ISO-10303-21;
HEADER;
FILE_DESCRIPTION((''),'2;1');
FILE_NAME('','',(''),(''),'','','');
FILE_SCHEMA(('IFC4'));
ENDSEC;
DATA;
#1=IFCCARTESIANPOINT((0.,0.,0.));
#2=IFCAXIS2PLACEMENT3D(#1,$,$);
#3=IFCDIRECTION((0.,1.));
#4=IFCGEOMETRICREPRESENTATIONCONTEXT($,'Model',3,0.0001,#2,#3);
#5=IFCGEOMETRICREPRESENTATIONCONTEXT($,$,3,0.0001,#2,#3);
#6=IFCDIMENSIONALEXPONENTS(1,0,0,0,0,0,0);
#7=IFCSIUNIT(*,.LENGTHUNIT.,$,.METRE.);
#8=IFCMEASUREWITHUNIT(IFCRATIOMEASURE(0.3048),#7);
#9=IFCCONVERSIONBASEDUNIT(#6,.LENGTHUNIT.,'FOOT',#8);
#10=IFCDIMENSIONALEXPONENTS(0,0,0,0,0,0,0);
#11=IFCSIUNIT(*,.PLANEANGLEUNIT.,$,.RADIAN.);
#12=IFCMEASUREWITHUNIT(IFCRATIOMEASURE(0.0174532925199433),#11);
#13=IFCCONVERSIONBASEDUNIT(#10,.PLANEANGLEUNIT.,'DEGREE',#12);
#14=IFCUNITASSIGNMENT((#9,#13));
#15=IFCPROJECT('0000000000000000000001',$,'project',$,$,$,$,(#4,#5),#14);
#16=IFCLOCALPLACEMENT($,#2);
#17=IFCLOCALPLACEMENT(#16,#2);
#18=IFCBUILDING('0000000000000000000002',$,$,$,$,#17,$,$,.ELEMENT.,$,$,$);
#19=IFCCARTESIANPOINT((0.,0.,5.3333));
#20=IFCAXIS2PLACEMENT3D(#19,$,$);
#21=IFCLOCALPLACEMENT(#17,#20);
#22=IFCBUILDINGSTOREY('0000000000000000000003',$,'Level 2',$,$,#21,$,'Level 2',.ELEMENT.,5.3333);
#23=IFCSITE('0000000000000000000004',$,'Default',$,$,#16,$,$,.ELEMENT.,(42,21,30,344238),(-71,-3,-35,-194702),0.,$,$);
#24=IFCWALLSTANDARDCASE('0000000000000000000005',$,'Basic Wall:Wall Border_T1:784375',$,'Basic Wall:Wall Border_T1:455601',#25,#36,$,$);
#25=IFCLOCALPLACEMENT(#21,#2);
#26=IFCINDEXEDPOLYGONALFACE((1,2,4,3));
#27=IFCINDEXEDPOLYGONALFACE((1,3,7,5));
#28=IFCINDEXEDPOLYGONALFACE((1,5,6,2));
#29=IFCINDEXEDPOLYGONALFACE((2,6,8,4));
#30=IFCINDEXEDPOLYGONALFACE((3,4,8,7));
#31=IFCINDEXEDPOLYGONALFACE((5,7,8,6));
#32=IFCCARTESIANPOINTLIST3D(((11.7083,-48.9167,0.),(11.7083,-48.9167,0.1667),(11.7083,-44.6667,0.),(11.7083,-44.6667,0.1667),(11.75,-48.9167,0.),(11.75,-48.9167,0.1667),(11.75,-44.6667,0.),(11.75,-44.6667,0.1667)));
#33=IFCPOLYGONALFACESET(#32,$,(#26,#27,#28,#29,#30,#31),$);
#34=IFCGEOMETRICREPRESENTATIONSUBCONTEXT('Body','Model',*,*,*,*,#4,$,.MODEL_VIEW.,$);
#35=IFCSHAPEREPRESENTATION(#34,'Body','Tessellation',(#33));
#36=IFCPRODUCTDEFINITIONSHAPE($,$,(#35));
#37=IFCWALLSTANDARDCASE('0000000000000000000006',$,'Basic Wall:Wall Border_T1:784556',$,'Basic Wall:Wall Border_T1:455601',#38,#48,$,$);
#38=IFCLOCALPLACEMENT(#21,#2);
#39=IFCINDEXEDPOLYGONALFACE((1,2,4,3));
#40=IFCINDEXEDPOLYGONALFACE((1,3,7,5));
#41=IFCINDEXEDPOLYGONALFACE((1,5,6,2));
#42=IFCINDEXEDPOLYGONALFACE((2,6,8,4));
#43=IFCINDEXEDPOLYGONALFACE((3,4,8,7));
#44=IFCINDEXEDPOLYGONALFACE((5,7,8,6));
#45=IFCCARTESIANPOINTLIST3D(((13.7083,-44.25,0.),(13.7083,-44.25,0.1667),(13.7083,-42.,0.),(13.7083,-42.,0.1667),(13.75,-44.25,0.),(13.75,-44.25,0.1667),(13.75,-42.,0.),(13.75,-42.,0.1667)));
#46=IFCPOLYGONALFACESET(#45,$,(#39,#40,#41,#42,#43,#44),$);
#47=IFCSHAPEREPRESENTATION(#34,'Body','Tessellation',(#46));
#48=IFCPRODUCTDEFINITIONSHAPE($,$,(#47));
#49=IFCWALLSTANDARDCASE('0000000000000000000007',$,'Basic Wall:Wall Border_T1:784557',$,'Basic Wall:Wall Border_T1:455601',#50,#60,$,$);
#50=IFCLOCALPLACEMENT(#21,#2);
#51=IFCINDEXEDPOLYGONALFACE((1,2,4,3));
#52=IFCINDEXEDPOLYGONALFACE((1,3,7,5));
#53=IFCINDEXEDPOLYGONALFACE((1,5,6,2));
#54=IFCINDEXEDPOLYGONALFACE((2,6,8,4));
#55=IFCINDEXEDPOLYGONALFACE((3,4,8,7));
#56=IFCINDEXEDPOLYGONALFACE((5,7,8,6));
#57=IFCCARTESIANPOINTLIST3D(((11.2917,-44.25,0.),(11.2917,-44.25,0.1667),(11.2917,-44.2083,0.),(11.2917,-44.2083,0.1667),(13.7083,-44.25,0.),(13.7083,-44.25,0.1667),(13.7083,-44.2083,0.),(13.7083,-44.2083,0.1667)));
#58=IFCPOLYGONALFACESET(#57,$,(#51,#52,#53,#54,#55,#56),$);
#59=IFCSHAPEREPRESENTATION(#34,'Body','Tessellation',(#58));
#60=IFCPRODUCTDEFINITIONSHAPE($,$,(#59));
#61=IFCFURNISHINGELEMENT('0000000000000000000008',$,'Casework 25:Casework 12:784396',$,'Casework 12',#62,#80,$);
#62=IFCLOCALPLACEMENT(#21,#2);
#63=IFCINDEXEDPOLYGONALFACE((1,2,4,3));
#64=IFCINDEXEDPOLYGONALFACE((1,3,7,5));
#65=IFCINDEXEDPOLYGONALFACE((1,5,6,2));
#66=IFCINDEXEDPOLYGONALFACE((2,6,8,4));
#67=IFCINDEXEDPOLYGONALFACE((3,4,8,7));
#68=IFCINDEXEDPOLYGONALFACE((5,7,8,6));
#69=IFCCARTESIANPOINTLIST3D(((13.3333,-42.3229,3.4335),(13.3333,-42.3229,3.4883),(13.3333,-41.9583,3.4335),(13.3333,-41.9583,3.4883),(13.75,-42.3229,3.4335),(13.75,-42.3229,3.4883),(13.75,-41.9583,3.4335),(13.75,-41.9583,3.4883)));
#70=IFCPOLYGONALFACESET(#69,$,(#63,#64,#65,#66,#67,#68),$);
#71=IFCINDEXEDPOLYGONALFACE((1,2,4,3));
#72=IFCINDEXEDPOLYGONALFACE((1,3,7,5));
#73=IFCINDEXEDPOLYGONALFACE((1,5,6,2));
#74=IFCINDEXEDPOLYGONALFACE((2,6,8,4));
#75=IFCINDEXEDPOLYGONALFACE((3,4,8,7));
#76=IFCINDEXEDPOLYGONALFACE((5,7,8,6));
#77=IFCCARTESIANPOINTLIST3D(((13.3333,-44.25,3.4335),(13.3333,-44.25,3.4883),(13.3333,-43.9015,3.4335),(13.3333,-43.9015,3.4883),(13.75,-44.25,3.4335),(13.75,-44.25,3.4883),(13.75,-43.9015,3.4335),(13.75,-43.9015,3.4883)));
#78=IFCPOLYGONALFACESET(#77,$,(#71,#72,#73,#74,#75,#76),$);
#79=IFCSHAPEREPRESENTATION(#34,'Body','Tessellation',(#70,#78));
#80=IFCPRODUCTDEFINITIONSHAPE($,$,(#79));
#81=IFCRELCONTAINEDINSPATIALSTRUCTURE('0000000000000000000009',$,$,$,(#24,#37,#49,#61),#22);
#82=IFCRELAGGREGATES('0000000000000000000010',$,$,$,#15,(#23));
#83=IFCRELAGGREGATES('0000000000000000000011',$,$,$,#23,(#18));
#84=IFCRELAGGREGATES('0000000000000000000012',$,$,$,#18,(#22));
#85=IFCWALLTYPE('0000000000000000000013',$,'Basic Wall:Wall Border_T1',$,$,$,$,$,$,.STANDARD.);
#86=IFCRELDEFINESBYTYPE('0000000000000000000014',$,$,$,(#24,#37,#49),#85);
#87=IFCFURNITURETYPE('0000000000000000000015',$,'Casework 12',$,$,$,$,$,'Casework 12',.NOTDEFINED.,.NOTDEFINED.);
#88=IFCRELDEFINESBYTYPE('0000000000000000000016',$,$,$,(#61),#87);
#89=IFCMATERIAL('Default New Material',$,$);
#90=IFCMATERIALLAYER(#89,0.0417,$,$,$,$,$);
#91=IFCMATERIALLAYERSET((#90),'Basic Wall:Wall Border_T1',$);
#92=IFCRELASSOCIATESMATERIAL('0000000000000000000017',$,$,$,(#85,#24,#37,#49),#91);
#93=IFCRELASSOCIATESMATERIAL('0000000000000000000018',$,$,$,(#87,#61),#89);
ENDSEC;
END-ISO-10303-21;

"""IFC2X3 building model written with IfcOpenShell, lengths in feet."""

from ifc_helpers import new_model, entity, si_unit, converted_unit, direction, frame, frame_2d, origin, origin_2d_with_axis, place, context, subcontext, project, spatial, rectangle, extrude, source, transform, mapped, material, layer, layer_set, layer_usage, type_object, type_shapes, element, save


model = new_model("IFC2X3")

# Units and contexts
model_context = context("Model", 3, precision=0.0001, world=origin(), true_north=direction((0.0, 1.0)))
context_of_model = context(None, 3, precision=0.0001, world=origin(), true_north=direction((0.0, 1.0)))
body_context = subcontext(model_context, "Body", "Model", "MODEL_VIEW")
ifc_project = project(units=[converted_unit("LENGTHUNIT", "FOOT", entity("IfcRatioMeasure", 0.3048), si_unit("LENGTHUNIT", "METRE"), dimensions=[1, 0, 0, 0, 0, 0, 0]), converted_unit("PLANEANGLEUNIT", "DEGREE", entity("IfcRatioMeasure", 0.0174532925199433), si_unit("PLANEANGLEUNIT", "RADIAN"), dimensions=[0, 0, 0, 0, 0, 0, 0])], contexts=[model_context, context_of_model])

# Site, building, storey
site_placement = place(None, origin())
site = spatial("IfcSite", under=ifc_project, at=site_placement, Name="Default", CompositionType="ELEMENT", RefLatitude=(42, 21, 30, 344238), RefLongitude=(-71, -3, -35, -194702), RefElevation=0.0)
building_placement = place(site_placement, origin())
building = spatial("IfcBuilding", under=site, at=building_placement, CompositionType="ELEMENT")
storey_placement = place(building_placement, frame((0.0, 0.0, 5.3333)))
storey = spatial("IfcBuildingStorey", under=building, at=storey_placement, Name="Level 2", LongName="Level 2", CompositionType="ELEMENT", Elevation=5.3333)

# Shared definitions
ifc_material_1 = material(Name="Default New Material")

# Walls
ifc_layer_1 = layer(ifc_material_1, 0.0417)
ifc_layer_set_1 = layer_set([ifc_layer_1], Name="Basic Wall:Wall Border_T1")
wall_type_1 = type_object("IfcWallType", Name="Basic Wall:Wall Border_T1", PredefinedType="STANDARD", material=ifc_layer_set_1)
ifc_layer_usage_1 = layer_usage(ifc_layer_set_1, "AXIS2", "NEGATIVE", 0.0208)
wall_1_placement = place(storey_placement, frame((11.7292, -44.6667, 0.0), z_axis=(0.0, 0.0, 1.0), x_axis=(0.0, -1.0, 0.0)))
element("IfcWallStandardCase", 1, at=wall_1_placement, inside=storey, type_object=wall_type_1, material=ifc_layer_usage_1, Name="Basic Wall:Wall Border_T1:784375", ObjectType="Basic Wall:Wall Border_T1:455601", context=body_context, shape_type="SweptSolid", body=[
    extrude(rectangle(XDim=4.25, YDim=0.0417, at=frame_2d((2.125, 0.0), x_axis=(-1.0, 0.0))), origin(), (0.0, 0.0, 1.0), 0.1667),
])
ifc_layer_usage_2 = layer_usage(ifc_layer_set_1, "AXIS2", "POSITIVE", -0.0208)
wall_2_placement = place(storey_placement, frame((13.7292, -42.0, 0.0), z_axis=(0.0, 0.0, 1.0), x_axis=(0.0, -1.0, 0.0)))
element("IfcWallStandardCase", 2, at=wall_2_placement, inside=storey, type_object=wall_type_1, material=ifc_layer_usage_2, Name="Basic Wall:Wall Border_T1:784556", ObjectType="Basic Wall:Wall Border_T1:455601", context=body_context, shape_type="SweptSolid", body=[
    extrude(rectangle(XDim=2.25, YDim=0.0417, at=frame_2d((1.125, 0.0), x_axis=(-1.0, 0.0))), origin(), (0.0, 0.0, 1.0), 0.1667),
])
ifc_layer_usage_3 = layer_usage(ifc_layer_set_1, "AXIS2", "POSITIVE", -0.0208)
wall_3_placement = place(storey_placement, frame((13.7083, -44.2292, 0.0), z_axis=(0.0, 0.0, 1.0), x_axis=(-1.0, 0.0, 0.0)))
element("IfcWallStandardCase", 3, at=wall_3_placement, inside=storey, type_object=wall_type_1, material=ifc_layer_usage_3, Name="Basic Wall:Wall Border_T1:784557", ObjectType="Basic Wall:Wall Border_T1:455601", context=body_context, shape_type="SweptSolid", body=[
    extrude(rectangle(XDim=2.4167, YDim=0.0417, at=frame_2d((1.2083, 0.0), x_axis=(-1.0, 0.0))), origin(), (0.0, 0.0, 1.0), 0.1667),
])

# Furnishing element
furniture_type_1 = type_object("IfcFurnitureType", Name="Casework 12", ElementType="Casework 12", AssemblyPlace="NOTDEFINED", material=ifc_material_1)
shared_shape_1 = source(origin(), body_context, "Body", "SweptSolid", [
    extrude(rectangle(XDim=0.3646, YDim=0.4167, at=frame_2d((0.0, 0.0), x_axis=(1.0, 0.0))), frame((0.2083, 2.1094, 0.0), z_axis=(0.0, 0.0, 1.0), x_axis=(0.0, -1.0, 0.0)), (0.0, 0.0, 1.0), 0.0548),
    extrude(rectangle(XDim=0.4167, YDim=0.3485, at=origin_2d_with_axis()), frame((0.2083, 0.1742, 0.0)), (0.0, 0.0, 1.0), 0.0548),
])
type_shapes(furniture_type_1, [shared_shape_1])
furnishing_1_placement = place(storey_placement, frame((13.3333, -44.25, 3.4335)))
element("IfcFurnishingElement", 4, at=furnishing_1_placement, inside=storey, type_object=furniture_type_1, material=ifc_material_1, Name="Casework 25:Casework 12:784396", ObjectType="Casework 12", context=body_context, shape_type="MappedRepresentation", body=[
    mapped(shared_shape_1, transform((0.0, 0.0, 0.0), scale=1.0)),
])

save(model, "model.ifc")
